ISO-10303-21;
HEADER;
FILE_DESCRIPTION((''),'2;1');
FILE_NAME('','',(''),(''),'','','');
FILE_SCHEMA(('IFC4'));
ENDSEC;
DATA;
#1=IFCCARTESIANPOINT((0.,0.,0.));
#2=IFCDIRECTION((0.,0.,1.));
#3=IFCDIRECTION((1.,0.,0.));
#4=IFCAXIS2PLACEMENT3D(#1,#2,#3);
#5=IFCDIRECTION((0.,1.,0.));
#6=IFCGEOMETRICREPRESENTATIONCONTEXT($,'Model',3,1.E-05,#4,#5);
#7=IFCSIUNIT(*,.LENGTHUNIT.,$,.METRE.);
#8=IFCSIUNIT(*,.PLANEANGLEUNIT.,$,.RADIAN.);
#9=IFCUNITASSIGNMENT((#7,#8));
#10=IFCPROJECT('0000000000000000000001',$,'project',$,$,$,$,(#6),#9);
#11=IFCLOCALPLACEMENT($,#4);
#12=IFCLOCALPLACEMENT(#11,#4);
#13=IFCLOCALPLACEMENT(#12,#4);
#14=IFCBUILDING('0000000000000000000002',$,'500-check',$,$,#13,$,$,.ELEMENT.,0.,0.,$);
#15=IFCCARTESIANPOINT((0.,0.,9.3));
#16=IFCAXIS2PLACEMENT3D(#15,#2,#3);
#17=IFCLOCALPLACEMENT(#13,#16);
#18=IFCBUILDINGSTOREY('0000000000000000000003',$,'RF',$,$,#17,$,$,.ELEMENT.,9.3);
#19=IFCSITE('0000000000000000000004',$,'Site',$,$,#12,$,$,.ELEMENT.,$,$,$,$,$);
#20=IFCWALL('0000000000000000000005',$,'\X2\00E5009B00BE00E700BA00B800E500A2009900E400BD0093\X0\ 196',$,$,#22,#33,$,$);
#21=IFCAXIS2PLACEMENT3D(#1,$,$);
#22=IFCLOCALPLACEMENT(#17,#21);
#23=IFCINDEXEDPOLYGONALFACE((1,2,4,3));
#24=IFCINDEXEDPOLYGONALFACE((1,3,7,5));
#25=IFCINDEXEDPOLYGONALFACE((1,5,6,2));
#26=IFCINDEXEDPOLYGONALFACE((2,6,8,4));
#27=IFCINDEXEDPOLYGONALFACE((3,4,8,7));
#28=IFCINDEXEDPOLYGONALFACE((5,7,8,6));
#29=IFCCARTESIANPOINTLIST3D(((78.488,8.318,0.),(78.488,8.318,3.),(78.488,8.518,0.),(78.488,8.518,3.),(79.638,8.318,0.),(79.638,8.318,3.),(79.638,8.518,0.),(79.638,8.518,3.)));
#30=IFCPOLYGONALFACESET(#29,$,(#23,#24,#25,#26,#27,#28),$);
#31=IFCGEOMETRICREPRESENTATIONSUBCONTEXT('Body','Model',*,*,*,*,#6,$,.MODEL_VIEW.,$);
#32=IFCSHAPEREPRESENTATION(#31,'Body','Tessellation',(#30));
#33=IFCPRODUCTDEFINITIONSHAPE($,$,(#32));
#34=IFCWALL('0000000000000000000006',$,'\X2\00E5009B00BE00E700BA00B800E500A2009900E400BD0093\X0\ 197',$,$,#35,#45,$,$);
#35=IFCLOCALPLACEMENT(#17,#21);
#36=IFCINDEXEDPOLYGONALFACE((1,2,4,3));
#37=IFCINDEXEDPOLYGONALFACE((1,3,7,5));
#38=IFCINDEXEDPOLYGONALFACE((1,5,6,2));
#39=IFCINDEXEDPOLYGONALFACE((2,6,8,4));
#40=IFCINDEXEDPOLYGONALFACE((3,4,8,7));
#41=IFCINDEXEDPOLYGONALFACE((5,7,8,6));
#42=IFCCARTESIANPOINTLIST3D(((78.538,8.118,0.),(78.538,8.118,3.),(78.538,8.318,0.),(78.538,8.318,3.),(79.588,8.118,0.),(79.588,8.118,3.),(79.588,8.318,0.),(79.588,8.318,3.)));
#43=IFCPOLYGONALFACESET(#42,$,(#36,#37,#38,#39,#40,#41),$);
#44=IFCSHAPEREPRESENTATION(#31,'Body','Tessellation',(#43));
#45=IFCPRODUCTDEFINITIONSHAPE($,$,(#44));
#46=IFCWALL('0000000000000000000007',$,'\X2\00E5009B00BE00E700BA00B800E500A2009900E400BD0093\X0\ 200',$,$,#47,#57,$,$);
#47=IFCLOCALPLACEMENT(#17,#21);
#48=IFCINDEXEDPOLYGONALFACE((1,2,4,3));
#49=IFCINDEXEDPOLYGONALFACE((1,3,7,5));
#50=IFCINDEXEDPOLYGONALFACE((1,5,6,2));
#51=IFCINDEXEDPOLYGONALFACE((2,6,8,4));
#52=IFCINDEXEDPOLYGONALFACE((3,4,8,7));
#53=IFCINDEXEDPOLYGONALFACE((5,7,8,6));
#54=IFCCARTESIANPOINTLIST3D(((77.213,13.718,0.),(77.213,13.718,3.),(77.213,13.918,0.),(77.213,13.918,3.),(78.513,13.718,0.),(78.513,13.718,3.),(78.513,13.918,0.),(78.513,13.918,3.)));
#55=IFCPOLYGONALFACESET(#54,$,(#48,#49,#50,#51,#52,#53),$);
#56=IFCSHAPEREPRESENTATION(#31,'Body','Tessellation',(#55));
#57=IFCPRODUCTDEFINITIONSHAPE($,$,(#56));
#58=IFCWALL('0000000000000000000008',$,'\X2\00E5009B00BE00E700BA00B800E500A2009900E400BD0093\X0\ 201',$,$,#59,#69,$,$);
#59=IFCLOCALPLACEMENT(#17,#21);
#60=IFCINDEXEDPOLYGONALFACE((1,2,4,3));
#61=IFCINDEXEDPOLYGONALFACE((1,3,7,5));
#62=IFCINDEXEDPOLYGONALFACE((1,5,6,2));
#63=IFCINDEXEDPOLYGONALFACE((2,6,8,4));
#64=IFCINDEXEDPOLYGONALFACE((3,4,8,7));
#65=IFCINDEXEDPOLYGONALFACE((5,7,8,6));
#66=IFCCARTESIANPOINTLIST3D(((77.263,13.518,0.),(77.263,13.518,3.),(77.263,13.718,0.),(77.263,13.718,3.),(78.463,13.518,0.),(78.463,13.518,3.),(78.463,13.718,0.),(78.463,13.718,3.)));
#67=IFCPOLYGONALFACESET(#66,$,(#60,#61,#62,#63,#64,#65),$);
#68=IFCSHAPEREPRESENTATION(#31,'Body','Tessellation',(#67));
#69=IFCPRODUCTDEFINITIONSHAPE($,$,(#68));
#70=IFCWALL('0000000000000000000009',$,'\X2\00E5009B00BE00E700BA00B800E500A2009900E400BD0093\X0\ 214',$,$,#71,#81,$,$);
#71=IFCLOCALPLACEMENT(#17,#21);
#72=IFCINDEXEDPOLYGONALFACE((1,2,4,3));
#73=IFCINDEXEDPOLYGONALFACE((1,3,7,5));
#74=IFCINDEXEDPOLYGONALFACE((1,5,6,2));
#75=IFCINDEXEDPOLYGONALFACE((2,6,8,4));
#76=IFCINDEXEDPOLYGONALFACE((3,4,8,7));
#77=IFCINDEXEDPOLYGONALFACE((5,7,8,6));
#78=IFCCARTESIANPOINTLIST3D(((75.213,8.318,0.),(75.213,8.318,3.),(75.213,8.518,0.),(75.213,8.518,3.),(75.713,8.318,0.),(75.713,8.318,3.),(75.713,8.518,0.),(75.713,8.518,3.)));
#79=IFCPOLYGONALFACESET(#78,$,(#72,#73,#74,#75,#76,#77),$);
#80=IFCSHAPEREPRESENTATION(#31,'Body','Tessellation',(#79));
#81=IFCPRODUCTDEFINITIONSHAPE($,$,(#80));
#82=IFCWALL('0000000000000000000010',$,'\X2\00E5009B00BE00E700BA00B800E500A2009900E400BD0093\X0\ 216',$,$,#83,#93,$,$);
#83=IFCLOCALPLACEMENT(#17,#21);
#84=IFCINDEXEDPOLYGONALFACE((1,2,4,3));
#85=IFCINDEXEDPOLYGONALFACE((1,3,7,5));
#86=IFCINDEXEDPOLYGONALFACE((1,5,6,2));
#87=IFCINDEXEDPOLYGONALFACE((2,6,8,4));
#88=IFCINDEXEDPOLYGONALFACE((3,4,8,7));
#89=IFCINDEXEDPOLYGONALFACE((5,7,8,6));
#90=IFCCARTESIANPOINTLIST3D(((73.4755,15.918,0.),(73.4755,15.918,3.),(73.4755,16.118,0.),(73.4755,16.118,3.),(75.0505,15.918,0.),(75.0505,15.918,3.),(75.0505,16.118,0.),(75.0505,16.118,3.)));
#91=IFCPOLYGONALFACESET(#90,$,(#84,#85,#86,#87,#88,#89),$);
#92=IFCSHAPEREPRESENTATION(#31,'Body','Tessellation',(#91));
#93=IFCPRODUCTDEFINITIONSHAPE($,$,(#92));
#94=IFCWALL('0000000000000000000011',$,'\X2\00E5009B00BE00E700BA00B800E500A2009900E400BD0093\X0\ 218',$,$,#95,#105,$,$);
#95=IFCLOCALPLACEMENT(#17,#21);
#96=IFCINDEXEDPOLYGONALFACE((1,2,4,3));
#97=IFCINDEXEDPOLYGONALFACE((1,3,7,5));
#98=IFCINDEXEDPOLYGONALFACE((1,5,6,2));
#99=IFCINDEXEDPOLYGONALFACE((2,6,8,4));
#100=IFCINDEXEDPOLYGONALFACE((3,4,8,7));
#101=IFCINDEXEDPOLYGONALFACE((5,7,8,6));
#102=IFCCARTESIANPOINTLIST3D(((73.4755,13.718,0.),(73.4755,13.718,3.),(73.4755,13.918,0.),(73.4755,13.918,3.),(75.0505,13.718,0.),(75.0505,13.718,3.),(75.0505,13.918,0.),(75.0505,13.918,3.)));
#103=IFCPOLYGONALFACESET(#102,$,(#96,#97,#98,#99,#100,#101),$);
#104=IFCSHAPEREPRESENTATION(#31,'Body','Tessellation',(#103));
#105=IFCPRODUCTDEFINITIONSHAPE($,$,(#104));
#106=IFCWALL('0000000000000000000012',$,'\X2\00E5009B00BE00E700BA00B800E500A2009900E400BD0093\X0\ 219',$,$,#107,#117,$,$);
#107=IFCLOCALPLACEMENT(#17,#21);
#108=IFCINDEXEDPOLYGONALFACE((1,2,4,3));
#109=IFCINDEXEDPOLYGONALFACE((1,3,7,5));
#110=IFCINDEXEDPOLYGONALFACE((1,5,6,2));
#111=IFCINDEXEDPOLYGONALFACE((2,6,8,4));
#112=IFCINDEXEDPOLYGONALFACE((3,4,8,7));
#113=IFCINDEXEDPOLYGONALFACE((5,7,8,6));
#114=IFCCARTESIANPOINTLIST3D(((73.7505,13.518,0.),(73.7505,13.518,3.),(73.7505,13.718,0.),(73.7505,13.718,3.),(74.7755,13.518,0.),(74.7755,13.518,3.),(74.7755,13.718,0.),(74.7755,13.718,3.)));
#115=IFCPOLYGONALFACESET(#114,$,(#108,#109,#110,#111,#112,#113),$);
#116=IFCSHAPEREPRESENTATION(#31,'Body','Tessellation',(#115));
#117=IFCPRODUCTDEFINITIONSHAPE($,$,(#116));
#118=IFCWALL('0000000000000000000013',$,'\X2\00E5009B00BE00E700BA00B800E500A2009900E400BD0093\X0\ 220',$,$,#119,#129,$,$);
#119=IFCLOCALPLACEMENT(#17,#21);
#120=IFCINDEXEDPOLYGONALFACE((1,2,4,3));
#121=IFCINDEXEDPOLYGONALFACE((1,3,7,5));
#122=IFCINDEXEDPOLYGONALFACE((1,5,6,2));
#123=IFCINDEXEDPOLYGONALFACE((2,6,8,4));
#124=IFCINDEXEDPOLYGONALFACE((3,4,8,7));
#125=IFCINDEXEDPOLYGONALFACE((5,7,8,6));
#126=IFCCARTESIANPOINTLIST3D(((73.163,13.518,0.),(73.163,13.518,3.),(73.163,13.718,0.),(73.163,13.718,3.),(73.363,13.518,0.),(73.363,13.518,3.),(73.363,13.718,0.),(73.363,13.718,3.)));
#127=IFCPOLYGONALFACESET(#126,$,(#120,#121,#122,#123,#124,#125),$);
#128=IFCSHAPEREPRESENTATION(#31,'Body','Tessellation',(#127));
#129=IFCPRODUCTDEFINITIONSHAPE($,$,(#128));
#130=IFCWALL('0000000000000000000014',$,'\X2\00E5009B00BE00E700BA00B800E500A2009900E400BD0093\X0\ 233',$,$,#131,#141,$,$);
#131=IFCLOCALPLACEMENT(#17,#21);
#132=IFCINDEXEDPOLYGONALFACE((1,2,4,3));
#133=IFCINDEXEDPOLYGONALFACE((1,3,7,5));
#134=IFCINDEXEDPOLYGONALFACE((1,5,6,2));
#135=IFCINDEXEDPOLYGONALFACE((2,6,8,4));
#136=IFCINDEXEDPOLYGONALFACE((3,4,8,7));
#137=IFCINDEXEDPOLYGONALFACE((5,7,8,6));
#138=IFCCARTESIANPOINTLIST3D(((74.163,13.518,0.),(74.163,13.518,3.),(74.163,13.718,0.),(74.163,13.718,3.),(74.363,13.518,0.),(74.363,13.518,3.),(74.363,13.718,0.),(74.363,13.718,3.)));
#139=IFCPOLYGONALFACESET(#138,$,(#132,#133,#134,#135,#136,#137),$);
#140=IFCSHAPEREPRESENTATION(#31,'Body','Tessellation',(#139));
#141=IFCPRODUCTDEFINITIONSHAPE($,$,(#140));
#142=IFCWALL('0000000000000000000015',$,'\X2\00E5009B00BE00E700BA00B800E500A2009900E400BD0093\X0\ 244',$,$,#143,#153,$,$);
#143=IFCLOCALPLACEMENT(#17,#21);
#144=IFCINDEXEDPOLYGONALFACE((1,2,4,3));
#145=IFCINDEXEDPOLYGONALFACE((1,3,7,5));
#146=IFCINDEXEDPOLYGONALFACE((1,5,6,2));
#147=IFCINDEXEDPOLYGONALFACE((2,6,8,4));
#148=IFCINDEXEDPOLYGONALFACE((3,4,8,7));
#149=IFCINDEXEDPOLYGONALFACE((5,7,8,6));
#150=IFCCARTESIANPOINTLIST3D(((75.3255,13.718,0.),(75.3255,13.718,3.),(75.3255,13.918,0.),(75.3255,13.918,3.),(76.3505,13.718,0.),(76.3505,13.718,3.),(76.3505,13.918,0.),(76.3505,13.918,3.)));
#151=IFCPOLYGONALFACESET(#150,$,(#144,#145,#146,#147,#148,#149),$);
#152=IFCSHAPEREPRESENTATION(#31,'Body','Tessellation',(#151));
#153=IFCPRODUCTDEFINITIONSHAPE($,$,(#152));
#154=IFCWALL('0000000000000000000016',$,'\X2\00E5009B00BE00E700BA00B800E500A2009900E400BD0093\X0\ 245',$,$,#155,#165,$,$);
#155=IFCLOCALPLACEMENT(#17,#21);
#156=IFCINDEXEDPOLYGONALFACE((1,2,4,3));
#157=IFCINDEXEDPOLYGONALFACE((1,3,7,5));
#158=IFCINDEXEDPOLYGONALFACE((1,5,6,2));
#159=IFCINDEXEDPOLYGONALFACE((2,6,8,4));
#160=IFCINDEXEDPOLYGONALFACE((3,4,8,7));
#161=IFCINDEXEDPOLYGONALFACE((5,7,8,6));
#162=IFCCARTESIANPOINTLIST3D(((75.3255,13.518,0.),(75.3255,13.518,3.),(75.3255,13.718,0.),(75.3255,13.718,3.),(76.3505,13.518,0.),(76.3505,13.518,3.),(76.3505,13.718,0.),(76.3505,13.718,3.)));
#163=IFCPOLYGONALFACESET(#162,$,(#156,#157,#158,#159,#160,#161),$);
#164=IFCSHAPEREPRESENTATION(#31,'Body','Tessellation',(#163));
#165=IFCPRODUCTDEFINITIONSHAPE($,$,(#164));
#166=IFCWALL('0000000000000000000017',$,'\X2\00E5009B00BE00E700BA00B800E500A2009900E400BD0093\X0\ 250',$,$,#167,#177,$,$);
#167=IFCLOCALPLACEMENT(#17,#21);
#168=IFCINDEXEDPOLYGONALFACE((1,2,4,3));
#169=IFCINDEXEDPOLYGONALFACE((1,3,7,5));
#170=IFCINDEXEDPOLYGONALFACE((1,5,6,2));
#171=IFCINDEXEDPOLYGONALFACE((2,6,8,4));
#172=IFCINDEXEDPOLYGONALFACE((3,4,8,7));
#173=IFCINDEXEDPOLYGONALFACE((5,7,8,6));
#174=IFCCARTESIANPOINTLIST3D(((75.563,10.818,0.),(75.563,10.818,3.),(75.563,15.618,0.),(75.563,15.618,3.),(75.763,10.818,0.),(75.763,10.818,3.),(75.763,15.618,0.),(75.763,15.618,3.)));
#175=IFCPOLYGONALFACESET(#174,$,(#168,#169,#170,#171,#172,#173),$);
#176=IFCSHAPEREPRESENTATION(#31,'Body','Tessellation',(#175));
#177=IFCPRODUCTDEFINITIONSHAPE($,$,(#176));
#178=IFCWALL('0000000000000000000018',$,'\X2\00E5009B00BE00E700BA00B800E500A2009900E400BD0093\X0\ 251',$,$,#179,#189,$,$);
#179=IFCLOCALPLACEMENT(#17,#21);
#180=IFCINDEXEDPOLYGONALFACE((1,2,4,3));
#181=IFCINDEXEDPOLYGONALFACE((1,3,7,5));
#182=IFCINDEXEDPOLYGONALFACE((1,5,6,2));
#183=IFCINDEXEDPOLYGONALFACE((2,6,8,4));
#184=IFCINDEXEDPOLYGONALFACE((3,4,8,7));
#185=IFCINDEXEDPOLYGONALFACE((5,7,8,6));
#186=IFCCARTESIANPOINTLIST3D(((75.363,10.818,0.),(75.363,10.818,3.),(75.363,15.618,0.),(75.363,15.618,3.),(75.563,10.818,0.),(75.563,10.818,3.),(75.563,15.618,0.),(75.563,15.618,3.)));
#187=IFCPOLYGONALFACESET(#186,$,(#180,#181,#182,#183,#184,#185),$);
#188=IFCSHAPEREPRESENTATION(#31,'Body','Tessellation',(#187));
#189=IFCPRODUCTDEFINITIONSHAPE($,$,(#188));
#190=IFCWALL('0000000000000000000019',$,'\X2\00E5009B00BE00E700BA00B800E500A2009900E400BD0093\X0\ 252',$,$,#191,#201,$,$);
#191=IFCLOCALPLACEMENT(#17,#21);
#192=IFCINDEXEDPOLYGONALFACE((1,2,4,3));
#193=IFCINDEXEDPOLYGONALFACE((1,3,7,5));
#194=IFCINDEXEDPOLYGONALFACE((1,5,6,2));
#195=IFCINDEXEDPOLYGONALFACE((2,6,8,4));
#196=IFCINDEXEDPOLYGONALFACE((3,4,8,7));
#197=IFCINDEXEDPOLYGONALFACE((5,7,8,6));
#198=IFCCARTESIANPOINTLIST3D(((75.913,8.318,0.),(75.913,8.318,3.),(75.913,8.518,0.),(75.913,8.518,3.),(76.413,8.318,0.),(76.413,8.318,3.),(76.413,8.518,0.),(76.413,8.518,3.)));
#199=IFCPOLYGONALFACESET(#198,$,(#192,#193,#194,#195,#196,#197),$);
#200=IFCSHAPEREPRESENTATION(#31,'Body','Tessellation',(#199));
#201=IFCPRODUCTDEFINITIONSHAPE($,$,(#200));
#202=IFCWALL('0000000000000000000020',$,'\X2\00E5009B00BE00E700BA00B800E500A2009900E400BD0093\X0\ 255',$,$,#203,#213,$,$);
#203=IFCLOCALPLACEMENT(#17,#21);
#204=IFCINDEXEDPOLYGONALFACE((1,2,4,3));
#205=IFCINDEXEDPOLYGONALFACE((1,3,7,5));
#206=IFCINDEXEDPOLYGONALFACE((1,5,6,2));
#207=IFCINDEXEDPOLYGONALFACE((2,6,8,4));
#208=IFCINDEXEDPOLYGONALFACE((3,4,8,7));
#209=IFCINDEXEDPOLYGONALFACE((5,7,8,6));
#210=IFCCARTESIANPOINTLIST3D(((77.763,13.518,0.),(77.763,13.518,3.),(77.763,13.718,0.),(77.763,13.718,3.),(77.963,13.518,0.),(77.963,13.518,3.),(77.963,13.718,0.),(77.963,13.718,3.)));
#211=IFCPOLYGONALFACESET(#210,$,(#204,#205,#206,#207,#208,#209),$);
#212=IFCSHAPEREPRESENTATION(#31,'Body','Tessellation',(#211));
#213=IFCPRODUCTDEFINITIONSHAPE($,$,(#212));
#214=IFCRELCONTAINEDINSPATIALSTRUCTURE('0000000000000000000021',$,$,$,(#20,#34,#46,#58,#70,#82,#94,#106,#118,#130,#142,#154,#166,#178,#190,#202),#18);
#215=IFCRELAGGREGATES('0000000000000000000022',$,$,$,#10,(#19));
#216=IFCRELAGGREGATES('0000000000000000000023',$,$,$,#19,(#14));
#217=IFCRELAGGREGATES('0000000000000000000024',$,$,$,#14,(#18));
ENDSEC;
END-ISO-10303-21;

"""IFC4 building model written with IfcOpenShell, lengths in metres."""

from ifc_helpers import new_model, si_unit, direction, frame, frame_2d, origin_with_axes, place, context, subcontext, project, spatial, rectangle, extrude, element, save


model = new_model("IFC4")

# Units and contexts
model_context = context("Model", 3, precision=1e-05, world=origin_with_axes(), true_north=direction((0.0, 1.0, 0.0)))
body_context = subcontext(model_context, "Body", "Model", "MODEL_VIEW")
ifc_project = project(units=[si_unit("LENGTHUNIT", "METRE"), si_unit("PLANEANGLEUNIT", "RADIAN")], contexts=[model_context])

# Site, building, storey
placement = place(None, origin_with_axes())
site_placement = place(placement, origin_with_axes())
site = spatial("IfcSite", under=ifc_project, at=site_placement, Name="Site", CompositionType="ELEMENT")
building_placement = place(site_placement, origin_with_axes())
building = spatial("IfcBuilding", under=site, at=building_placement, Name="500-check", CompositionType="ELEMENT", ElevationOfRefHeight=0.0, ElevationOfTerrain=0.0)
storey_placement = place(building_placement, frame((0.0, 0.0, 9.3), z_axis=(0.0, 0.0, 1.0), x_axis=(1.0, 0.0, 0.0)))
storey = spatial("IfcBuildingStorey", under=building, at=storey_placement, Name="RF", CompositionType="ELEMENT", Elevation=9.3)

# Walls
wall_1_placement = place(storey_placement, frame((79.063, 8.418, 0.0), z_axis=(0.0, 0.0, 1.0), x_axis=(-1.0, 0.0, 0.0)))
element("IfcWall", 1, at=wall_1_placement, inside=storey, Name="å\u009b¾çº¸å¢\u0099ä½\u0093 196", context=body_context, shape_type="SweptSolid", body=[
    extrude(rectangle(XDim=1.15, YDim=0.2, at=frame_2d((0.0, 0.0), x_axis=(1.0, 0.0, 0.0))), frame((0.0, 0.0, 0.0), z_axis=(0.0, 0.0, 1.0)), (0.0, 0.0, 1.0), 3.0),
])
wall_2_placement = place(storey_placement, frame((79.063, 8.218, 0.0), z_axis=(0.0, 0.0, 1.0), x_axis=(-1.0, 0.0, 0.0)))
element("IfcWall", 2, at=wall_2_placement, inside=storey, Name="å\u009b¾çº¸å¢\u0099ä½\u0093 197", context=body_context, shape_type="SweptSolid", body=[
    extrude(rectangle(XDim=1.05, YDim=0.2, at=frame_2d((0.0, 0.0), x_axis=(1.0, 0.0, 0.0))), frame((0.0, 0.0, 0.0), z_axis=(0.0, 0.0, 1.0)), (0.0, 0.0, 1.0), 3.0),
])
wall_3_placement = place(storey_placement, frame((77.863, 13.818, 0.0), z_axis=(0.0, 0.0, 1.0), x_axis=(1.0, 0.0, 0.0)))
element("IfcWall", 3, at=wall_3_placement, inside=storey, Name="å\u009b¾çº¸å¢\u0099ä½\u0093 200", context=body_context, shape_type="SweptSolid", body=[
    extrude(rectangle(XDim=1.3, YDim=0.2, at=frame_2d((0.0, 0.0), x_axis=(1.0, 0.0, 0.0))), frame((0.0, 0.0, 0.0), z_axis=(0.0, 0.0, 1.0)), (0.0, 0.0, 1.0), 3.0),
])
wall_4_placement = place(storey_placement, frame((77.863, 13.618, 0.0), z_axis=(0.0, 0.0, 1.0), x_axis=(1.0, 0.0, 0.0)))
element("IfcWall", 4, at=wall_4_placement, inside=storey, Name="å\u009b¾çº¸å¢\u0099ä½\u0093 201", context=body_context, shape_type="SweptSolid", body=[
    extrude(rectangle(XDim=1.2, YDim=0.2, at=frame_2d((0.0, 0.0), x_axis=(1.0, 0.0, 0.0))), frame((0.0, 0.0, 0.0), z_axis=(0.0, 0.0, 1.0)), (0.0, 0.0, 1.0), 3.0),
])
wall_5_placement = place(storey_placement, frame((75.463, 8.418, 0.0), z_axis=(0.0, 0.0, 1.0), x_axis=(-1.0, 0.0, 0.0)))
element("IfcWall", 5, at=wall_5_placement, inside=storey, Name="å\u009b¾çº¸å¢\u0099ä½\u0093 214", context=body_context, shape_type="SweptSolid", body=[
    extrude(rectangle(XDim=0.5, YDim=0.2, at=frame_2d((0.0, 0.0), x_axis=(1.0, 0.0, 0.0))), frame((0.0, 0.0, 0.0), z_axis=(0.0, 0.0, 1.0)), (0.0, 0.0, 1.0), 3.0),
])
for number, where, z_axis, x_axis, name in (
    (6, (74.263, 16.018, 0.0), (0.0, 0.0, 1.0), (1.0, 0.0, 0.0), "å\u009b¾çº¸å¢\u0099ä½\u0093 216"),
    (7, (74.263, 13.818, 0.0), (0.0, 0.0, 1.0), (1.0, 0.0, 0.0), "å\u009b¾çº¸å¢\u0099ä½\u0093 218"),
):
    element("IfcWall", number, at=place(storey_placement, frame(where, z_axis=z_axis, x_axis=x_axis)), inside=storey, Name=name, context=body_context, shape_type="SweptSolid", body=[
        extrude(rectangle(XDim=1.575, YDim=0.2, at=frame_2d((0.0, 0.0), x_axis=(1.0, 0.0, 0.0))), frame((0.0, 0.0, 0.0), z_axis=(0.0, 0.0, 1.0)), (0.0, 0.0, 1.0), 3.0),
    ])
wall_6_placement = place(storey_placement, frame((74.263, 13.618, 0.0), z_axis=(0.0, 0.0, 1.0), x_axis=(1.0, 0.0, 0.0)))
element("IfcWall", 8, at=wall_6_placement, inside=storey, Name="å\u009b¾çº¸å¢\u0099ä½\u0093 219", context=body_context, shape_type="SweptSolid", body=[
    extrude(rectangle(XDim=1.025, YDim=0.2, at=frame_2d((0.0, 0.0), x_axis=(1.0, 0.0, 0.0))), frame((0.0, 0.0, 0.0), z_axis=(0.0, 0.0, 1.0)), (0.0, 0.0, 1.0), 3.0),
])
for number, where, z_axis, x_axis, name in (
    (9, (73.263, 13.618, 0.0), (0.0, 0.0, 1.0), (0.0, 1.0, 0.0), "å\u009b¾çº¸å¢\u0099ä½\u0093 220"),
    (10, (74.263, 13.618, 0.0), (0.0, 0.0, 1.0), (0.0, 1.0, 0.0), "å\u009b¾çº¸å¢\u0099ä½\u0093 233"),
):
    element("IfcWall", number, at=place(storey_placement, frame(where, z_axis=z_axis, x_axis=x_axis)), inside=storey, Name=name, context=body_context, shape_type="SweptSolid", body=[
        extrude(rectangle(XDim=0.2, YDim=0.2, at=frame_2d((0.0, 0.0), x_axis=(1.0, 0.0, 0.0))), frame((0.0, 0.0, 0.0), z_axis=(0.0, 0.0, 1.0)), (0.0, 0.0, 1.0), 3.0),
    ])
for number, where, z_axis, x_axis, name in (
    (11, (75.838, 13.818, 0.0), (0.0, 0.0, 1.0), (1.0, 0.0, 0.0), "å\u009b¾çº¸å¢\u0099ä½\u0093 244"),
    (12, (75.838, 13.618, 0.0), (0.0, 0.0, 1.0), (1.0, 0.0, 0.0), "å\u009b¾çº¸å¢\u0099ä½\u0093 245"),
):
    element("IfcWall", number, at=place(storey_placement, frame(where, z_axis=z_axis, x_axis=x_axis)), inside=storey, Name=name, context=body_context, shape_type="SweptSolid", body=[
        extrude(rectangle(XDim=1.025, YDim=0.2, at=frame_2d((0.0, 0.0), x_axis=(1.0, 0.0, 0.0))), frame((0.0, 0.0, 0.0), z_axis=(0.0, 0.0, 1.0)), (0.0, 0.0, 1.0), 3.0),
    ])
for number, where, z_axis, x_axis, name in (
    (13, (75.663, 13.218, 0.0), (0.0, 0.0, 1.0), (0.0, -1.0, 0.0), "å\u009b¾çº¸å¢\u0099ä½\u0093 250"),
    (14, (75.463, 13.218, 0.0), (0.0, 0.0, 1.0), (0.0, -1.0, 0.0), "å\u009b¾çº¸å¢\u0099ä½\u0093 251"),
):
    element("IfcWall", number, at=place(storey_placement, frame(where, z_axis=z_axis, x_axis=x_axis)), inside=storey, Name=name, context=body_context, shape_type="SweptSolid", body=[
        extrude(rectangle(XDim=4.8, YDim=0.2, at=frame_2d((0.0, 0.0), x_axis=(1.0, 0.0, 0.0))), frame((0.0, 0.0, 0.0), z_axis=(0.0, 0.0, 1.0)), (0.0, 0.0, 1.0), 3.0),
    ])
wall_7_placement = place(storey_placement, frame((76.163, 8.418, 0.0), z_axis=(0.0, 0.0, 1.0), x_axis=(-1.0, 0.0, 0.0)))
element("IfcWall", 15, at=wall_7_placement, inside=storey, Name="å\u009b¾çº¸å¢\u0099ä½\u0093 252", context=body_context, shape_type="SweptSolid", body=[
    extrude(rectangle(XDim=0.5, YDim=0.2, at=frame_2d((0.0, 0.0), x_axis=(1.0, 0.0, 0.0))), frame((0.0, 0.0, 0.0), z_axis=(0.0, 0.0, 1.0)), (0.0, 0.0, 1.0), 3.0),
])
for number, where, z_axis, x_axis, name in (
    (16, (77.863, 13.618, 0.0), (0.0, 0.0, 1.0), (0.0, 1.0, 0.0), "å\u009b¾çº¸å¢\u0099ä½\u0093 255"),
):
    element("IfcWall", number, at=place(storey_placement, frame(where, z_axis=z_axis, x_axis=x_axis)), inside=storey, Name=name, context=body_context, shape_type="SweptSolid", body=[
        extrude(rectangle(XDim=0.2, YDim=0.2, at=frame_2d((0.0, 0.0), x_axis=(1.0, 0.0, 0.0))), frame((0.0, 0.0, 0.0), z_axis=(0.0, 0.0, 1.0)), (0.0, 0.0, 1.0), 3.0),
    ])

save(model, "model.ifc")
